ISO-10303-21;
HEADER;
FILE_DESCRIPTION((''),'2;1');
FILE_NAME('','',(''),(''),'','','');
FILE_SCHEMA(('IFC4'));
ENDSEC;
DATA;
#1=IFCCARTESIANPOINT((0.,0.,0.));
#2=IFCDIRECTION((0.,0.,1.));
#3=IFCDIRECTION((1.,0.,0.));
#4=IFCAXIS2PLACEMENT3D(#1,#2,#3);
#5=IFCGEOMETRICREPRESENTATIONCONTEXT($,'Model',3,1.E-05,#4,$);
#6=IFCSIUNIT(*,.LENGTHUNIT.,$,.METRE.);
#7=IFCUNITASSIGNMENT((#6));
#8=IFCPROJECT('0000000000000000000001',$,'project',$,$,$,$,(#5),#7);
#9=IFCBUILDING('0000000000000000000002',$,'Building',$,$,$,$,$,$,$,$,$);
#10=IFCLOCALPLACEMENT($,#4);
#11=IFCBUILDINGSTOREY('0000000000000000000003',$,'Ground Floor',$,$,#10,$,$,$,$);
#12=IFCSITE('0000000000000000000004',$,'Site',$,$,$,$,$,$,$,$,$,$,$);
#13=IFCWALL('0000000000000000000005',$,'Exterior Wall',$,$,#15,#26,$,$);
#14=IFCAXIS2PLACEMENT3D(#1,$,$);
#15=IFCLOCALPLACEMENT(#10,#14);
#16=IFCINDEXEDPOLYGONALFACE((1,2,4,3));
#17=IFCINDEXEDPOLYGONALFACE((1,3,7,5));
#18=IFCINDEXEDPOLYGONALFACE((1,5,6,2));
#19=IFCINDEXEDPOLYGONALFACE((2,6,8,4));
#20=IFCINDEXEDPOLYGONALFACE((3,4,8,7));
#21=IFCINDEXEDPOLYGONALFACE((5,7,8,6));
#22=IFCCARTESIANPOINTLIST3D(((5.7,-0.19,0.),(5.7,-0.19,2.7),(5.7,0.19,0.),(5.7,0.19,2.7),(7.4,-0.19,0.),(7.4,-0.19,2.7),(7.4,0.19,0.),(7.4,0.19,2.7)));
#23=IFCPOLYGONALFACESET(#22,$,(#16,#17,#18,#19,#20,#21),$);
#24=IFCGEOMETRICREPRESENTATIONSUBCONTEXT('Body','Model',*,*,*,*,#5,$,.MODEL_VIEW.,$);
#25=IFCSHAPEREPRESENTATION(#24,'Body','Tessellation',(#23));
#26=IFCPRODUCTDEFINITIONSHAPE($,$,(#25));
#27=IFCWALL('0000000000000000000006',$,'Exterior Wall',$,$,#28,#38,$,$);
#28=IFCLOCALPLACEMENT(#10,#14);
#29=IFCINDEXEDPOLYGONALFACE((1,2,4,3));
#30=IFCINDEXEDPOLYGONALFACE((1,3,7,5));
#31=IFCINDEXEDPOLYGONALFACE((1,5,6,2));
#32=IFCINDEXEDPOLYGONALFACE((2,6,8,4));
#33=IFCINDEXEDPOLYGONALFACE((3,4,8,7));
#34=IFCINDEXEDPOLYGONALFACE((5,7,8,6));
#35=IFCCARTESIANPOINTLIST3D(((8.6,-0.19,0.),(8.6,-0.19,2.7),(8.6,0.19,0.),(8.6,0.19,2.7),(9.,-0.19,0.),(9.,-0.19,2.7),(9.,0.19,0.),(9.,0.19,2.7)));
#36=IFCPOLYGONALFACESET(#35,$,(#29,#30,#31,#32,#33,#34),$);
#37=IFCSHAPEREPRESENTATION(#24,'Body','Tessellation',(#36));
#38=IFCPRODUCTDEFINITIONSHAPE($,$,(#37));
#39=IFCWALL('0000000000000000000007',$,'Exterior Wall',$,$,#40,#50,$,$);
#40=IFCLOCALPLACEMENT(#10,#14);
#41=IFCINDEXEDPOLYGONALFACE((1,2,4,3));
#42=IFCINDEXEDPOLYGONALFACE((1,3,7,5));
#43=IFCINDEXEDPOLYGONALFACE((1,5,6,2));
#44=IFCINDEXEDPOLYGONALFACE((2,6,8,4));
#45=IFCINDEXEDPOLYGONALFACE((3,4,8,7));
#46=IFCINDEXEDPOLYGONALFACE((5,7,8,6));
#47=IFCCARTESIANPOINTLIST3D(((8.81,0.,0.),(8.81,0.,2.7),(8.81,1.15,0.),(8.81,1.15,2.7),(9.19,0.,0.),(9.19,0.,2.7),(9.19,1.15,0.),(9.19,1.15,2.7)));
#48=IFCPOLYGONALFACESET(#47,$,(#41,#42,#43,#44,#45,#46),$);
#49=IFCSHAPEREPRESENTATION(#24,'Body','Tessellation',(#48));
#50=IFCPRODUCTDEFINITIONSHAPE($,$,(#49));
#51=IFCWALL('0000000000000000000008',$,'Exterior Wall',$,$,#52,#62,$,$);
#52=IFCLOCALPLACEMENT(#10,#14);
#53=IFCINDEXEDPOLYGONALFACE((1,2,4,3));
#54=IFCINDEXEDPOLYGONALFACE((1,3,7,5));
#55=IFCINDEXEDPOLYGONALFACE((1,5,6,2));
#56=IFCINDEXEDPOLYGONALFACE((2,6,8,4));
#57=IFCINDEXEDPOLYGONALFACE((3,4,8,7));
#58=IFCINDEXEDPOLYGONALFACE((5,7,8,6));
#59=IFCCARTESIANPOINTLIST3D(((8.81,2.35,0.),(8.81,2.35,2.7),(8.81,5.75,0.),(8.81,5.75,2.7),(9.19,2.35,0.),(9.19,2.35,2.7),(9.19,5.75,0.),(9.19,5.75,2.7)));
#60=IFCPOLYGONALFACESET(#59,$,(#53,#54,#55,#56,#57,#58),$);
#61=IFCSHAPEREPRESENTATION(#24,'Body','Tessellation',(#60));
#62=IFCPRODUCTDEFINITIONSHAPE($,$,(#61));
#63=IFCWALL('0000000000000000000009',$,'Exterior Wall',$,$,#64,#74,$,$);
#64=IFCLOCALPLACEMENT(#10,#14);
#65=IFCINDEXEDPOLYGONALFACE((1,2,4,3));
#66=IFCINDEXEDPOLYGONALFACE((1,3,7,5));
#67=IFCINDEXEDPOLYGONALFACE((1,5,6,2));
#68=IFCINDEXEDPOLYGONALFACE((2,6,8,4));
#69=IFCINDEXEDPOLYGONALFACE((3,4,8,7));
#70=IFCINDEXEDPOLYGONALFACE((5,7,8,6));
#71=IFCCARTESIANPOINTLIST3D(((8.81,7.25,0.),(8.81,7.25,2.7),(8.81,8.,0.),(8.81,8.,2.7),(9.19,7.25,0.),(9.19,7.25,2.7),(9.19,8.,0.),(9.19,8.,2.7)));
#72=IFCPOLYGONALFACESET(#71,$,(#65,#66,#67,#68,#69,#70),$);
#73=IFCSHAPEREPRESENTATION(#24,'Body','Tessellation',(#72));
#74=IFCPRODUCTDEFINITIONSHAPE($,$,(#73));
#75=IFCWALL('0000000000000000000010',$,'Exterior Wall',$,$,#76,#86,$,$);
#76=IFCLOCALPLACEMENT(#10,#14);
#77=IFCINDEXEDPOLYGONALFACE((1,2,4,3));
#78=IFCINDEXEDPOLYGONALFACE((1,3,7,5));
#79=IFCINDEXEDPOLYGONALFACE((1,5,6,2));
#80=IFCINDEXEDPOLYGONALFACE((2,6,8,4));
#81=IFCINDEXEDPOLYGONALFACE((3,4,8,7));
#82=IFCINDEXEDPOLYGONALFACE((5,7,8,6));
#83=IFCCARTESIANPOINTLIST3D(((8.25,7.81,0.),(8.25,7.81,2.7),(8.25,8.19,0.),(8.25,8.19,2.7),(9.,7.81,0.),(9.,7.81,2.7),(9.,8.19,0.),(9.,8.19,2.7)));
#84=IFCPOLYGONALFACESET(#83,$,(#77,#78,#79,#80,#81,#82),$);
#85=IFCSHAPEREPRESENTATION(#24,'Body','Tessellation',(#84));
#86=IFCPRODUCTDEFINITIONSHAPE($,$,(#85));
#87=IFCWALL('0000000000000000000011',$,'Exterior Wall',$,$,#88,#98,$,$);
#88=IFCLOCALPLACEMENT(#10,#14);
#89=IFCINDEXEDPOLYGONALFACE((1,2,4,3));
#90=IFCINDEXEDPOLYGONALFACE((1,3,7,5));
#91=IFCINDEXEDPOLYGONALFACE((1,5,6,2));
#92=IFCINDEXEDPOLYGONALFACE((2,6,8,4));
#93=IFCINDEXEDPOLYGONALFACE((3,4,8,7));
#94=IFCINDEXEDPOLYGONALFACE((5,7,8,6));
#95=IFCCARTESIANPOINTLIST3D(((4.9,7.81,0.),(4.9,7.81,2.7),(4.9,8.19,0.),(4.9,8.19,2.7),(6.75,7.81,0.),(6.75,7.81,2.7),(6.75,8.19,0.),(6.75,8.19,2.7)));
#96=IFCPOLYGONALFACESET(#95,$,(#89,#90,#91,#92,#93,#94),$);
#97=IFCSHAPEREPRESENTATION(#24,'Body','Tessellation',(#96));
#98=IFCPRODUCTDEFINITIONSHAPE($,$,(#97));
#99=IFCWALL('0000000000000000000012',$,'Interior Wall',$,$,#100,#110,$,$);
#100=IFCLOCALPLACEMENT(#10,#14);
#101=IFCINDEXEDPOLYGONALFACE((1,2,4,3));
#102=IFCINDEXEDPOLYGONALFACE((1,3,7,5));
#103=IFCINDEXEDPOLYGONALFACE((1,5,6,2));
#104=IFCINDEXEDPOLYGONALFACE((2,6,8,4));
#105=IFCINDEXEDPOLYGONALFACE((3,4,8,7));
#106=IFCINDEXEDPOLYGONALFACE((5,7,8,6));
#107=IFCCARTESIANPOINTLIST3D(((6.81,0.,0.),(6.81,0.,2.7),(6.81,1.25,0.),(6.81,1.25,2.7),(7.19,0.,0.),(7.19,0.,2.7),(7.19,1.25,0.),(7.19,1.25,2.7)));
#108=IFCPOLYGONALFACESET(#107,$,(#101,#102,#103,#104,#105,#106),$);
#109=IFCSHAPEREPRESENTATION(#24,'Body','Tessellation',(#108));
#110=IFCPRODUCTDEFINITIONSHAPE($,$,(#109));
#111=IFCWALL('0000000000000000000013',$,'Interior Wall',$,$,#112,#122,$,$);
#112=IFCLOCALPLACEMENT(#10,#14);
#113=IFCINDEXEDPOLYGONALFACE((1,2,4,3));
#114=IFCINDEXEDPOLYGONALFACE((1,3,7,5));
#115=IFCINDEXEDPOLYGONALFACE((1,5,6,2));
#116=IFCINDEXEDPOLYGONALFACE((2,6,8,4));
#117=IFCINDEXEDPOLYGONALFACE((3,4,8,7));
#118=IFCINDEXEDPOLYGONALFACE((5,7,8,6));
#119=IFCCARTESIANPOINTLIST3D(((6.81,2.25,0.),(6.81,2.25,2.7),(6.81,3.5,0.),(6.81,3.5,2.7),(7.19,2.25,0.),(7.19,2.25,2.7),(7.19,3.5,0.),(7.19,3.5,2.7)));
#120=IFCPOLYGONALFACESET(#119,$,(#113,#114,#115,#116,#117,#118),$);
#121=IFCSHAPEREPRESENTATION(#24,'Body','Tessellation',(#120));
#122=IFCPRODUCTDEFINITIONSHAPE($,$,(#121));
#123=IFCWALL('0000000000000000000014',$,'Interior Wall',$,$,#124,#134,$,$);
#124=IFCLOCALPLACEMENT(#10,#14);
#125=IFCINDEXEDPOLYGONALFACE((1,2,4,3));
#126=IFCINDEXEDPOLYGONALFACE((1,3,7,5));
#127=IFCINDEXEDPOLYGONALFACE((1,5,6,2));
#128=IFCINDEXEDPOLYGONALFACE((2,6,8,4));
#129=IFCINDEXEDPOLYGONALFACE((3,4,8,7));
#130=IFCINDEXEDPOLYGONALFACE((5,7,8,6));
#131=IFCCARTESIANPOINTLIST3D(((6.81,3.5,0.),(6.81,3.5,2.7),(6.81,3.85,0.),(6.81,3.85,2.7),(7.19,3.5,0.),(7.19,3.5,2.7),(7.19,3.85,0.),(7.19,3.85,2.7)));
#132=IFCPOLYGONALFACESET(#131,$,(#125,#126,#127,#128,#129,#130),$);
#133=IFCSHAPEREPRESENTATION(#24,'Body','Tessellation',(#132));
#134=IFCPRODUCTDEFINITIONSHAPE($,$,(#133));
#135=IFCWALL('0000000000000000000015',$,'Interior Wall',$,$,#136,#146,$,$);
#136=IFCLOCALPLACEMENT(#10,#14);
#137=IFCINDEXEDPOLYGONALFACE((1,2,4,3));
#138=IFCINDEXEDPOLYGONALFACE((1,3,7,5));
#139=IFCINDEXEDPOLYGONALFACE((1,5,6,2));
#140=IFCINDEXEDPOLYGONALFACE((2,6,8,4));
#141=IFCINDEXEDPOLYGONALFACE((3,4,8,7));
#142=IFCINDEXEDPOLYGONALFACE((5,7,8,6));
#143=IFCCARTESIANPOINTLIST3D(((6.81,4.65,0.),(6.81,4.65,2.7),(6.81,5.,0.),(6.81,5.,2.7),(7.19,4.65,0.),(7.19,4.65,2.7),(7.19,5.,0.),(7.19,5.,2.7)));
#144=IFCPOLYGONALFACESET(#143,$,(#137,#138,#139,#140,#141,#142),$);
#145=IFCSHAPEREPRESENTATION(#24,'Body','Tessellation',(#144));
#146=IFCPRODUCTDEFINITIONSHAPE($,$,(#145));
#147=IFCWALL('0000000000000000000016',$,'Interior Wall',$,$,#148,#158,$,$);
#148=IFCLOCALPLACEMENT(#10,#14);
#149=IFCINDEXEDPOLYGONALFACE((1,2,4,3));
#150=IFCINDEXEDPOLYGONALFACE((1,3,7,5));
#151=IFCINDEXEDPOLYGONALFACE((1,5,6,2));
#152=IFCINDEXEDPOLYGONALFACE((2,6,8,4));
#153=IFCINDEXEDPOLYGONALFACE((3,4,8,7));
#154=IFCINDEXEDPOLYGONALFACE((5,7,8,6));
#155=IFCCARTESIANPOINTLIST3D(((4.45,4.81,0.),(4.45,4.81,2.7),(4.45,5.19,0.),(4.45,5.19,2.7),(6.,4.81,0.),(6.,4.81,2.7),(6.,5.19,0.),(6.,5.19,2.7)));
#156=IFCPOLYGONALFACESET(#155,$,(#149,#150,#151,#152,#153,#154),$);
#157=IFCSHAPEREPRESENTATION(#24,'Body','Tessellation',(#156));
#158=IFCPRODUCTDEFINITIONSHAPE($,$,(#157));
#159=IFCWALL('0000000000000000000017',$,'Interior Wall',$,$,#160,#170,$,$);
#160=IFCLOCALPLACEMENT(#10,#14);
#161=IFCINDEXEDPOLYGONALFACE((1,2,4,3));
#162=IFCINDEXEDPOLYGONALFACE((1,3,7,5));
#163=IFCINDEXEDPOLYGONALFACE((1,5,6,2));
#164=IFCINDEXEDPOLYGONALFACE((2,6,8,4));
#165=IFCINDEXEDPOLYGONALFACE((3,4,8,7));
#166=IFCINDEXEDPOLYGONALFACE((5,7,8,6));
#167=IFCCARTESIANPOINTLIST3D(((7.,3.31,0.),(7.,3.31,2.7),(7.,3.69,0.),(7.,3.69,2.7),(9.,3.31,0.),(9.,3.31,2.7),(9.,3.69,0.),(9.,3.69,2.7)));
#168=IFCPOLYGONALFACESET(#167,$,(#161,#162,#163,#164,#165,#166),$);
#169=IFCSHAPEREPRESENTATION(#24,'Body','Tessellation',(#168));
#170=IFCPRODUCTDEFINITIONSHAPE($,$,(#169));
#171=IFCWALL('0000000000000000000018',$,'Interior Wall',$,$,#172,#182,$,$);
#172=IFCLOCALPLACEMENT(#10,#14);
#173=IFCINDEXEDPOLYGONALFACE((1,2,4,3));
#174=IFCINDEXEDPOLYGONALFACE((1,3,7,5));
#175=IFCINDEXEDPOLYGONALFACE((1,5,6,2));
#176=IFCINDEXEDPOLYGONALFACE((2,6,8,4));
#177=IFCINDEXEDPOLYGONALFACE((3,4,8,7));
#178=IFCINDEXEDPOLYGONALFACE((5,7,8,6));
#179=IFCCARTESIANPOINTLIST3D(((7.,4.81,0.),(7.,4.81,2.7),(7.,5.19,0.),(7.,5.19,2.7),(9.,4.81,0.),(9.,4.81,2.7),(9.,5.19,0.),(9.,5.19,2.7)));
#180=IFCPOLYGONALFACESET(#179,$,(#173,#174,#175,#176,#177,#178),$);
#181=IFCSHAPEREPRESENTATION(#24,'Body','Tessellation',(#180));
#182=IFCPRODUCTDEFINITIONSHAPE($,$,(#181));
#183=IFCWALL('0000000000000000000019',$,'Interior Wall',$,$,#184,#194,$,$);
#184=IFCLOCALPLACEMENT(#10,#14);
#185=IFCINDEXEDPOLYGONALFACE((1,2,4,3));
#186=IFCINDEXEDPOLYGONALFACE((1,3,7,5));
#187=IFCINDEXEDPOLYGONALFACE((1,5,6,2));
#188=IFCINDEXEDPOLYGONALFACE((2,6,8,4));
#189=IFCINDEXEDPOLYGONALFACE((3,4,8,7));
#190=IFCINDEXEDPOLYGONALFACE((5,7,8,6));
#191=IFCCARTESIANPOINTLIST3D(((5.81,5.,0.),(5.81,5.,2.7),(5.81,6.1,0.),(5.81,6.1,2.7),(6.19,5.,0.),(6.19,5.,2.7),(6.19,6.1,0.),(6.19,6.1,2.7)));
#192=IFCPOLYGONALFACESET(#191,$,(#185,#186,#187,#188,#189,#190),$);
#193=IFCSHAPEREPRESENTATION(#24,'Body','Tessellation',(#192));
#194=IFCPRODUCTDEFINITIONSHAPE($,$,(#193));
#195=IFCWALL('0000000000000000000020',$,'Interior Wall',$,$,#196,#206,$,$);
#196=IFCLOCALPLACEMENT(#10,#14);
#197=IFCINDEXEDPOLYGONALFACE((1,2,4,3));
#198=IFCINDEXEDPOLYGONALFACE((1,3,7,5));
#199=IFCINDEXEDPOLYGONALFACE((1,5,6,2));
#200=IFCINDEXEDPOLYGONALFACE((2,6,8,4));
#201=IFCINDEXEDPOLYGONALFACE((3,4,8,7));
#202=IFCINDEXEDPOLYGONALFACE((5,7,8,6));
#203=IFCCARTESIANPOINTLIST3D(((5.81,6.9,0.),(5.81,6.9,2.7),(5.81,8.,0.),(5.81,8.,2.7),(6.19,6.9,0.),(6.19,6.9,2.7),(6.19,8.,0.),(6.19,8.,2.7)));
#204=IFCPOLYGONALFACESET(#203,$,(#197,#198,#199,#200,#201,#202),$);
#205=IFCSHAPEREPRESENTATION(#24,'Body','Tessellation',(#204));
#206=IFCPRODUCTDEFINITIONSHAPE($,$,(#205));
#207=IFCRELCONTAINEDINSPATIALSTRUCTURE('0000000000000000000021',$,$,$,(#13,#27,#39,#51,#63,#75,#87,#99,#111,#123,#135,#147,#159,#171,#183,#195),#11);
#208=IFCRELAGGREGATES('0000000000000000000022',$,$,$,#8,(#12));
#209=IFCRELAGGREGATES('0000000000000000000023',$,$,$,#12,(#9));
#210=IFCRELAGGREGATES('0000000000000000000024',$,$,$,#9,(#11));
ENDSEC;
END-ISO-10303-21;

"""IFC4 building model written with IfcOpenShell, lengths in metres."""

from ifc_helpers import new_model, si_unit, frame, origin_with_axes, place, context, subcontext, project, spatial, indexed_curve, outline, extrude, element, save


model = new_model("IFC4")

# Units and contexts
model_context = context("Model", 3, precision=1e-05, world=origin_with_axes())
body_context = subcontext(model_context, "Body", "Model", "MODEL_VIEW")
ifc_project = project(units=[si_unit("LENGTHUNIT", "METRE")], contexts=[model_context])

# Site, building, storey
site = spatial("IfcSite", under=ifc_project, Name="Site")
building = spatial("IfcBuilding", under=site, Name="Building")
storey_placement = place(None, origin_with_axes())
storey = spatial("IfcBuildingStorey", under=building, at=storey_placement, Name="Ground Floor")

# Walls
wall_1_placement = place(storey_placement, frame((5.7, 0.0, 0.0), z_axis=(0.0, 0.0, 1.0), x_axis=(1.0, 0.0, 0.0)))
element("IfcWall", 1, at=wall_1_placement, inside=storey, Name="Exterior Wall", context=body_context, shape_type="SweptSolid", body=[
    extrude(outline(indexed_curve([(0.0, 0.0), (0.0, 0.38), (1.7, 0.38), (1.7, 0.0), (0.0, 0.0)], self_intersect=False)), frame((0.0, -0.19, 0.0), z_axis=(0.0, 0.0, 1.0), x_axis=(1.0, 0.0, 0.0)), (0.0, 0.0, 1.0), 2.7),
])
wall_2_placement = place(storey_placement, frame((8.6, 0.0, 0.0), z_axis=(0.0, 0.0, 1.0), x_axis=(1.0, 0.0, 0.0)))
element("IfcWall", 2, at=wall_2_placement, inside=storey, Name="Exterior Wall", context=body_context, shape_type="SweptSolid", body=[
    extrude(outline(indexed_curve([(0.0, 0.0), (0.0, 0.38), (0.4, 0.38), (0.4, 0.0), (0.0, 0.0)], self_intersect=False)), frame((0.0, -0.19, 0.0), z_axis=(0.0, 0.0, 1.0), x_axis=(1.0, 0.0, 0.0)), (0.0, 0.0, 1.0), 2.7),
])
wall_3_placement = place(storey_placement, frame((9.0, 0.0, 0.0), z_axis=(0.0, 0.0, 1.0), x_axis=(0.0, 1.0, 0.0)))
element("IfcWall", 3, at=wall_3_placement, inside=storey, Name="Exterior Wall", context=body_context, shape_type="SweptSolid", body=[
    extrude(outline(indexed_curve([(0.0, 0.0), (0.0, 0.38), (1.15, 0.38), (1.15, 0.0), (0.0, 0.0)], self_intersect=False)), frame((0.0, -0.19, 0.0), z_axis=(0.0, 0.0, 1.0), x_axis=(1.0, 0.0, 0.0)), (0.0, 0.0, 1.0), 2.7),
])
wall_4_placement = place(storey_placement, frame((9.0, 2.35, 0.0), z_axis=(0.0, 0.0, 1.0), x_axis=(0.0, 1.0, 0.0)))
element("IfcWall", 4, at=wall_4_placement, inside=storey, Name="Exterior Wall", context=body_context, shape_type="SweptSolid", body=[
    extrude(outline(indexed_curve([(0.0, 0.0), (0.0, 0.38), (3.4, 0.38), (3.4, 0.0), (0.0, 0.0)], self_intersect=False)), frame((0.0, -0.19, 0.0), z_axis=(0.0, 0.0, 1.0), x_axis=(1.0, 0.0, 0.0)), (0.0, 0.0, 1.0), 2.7),
])
for number, where, z_axis, x_axis, name in (
    (5, (9.0, 7.25, 0.0), (0.0, 0.0, 1.0), (0.0, 1.0, 0.0), "Exterior Wall"),
    (6, (9.0, 8.0, 0.0), (0.0, 0.0, 1.0), (-1.0, 0.0, 0.0), "Exterior Wall"),
):
    element("IfcWall", number, at=place(storey_placement, frame(where, z_axis=z_axis, x_axis=x_axis)), inside=storey, Name=name, context=body_context, shape_type="SweptSolid", body=[
        extrude(outline(indexed_curve([(0.0, 0.0), (0.0, 0.38), (0.75, 0.38), (0.75, 0.0), (0.0, 0.0)], self_intersect=False)), frame((0.0, -0.19, 0.0), z_axis=(0.0, 0.0, 1.0), x_axis=(1.0, 0.0, 0.0)), (0.0, 0.0, 1.0), 2.7),
    ])
wall_5_placement = place(storey_placement, frame((6.75, 8.0, 0.0), z_axis=(0.0, 0.0, 1.0), x_axis=(-1.0, 0.0, 0.0)))
element("IfcWall", 7, at=wall_5_placement, inside=storey, Name="Exterior Wall", context=body_context, shape_type="SweptSolid", body=[
    extrude(outline(indexed_curve([(0.0, 0.0), (0.0, 0.38), (1.85, 0.38), (1.85, 0.0), (0.0, 0.0)], self_intersect=False)), frame((0.0, -0.19, 0.0), z_axis=(0.0, 0.0, 1.0), x_axis=(1.0, 0.0, 0.0)), (0.0, 0.0, 1.0), 2.7),
])
for number, where, z_axis, x_axis, name in (
    (8, (7.0, 0.0, 0.0), (0.0, 0.0, 1.0), (0.0, 1.0, 0.0), "Interior Wall"),
    (9, (7.0, 2.25, 0.0), (0.0, 0.0, 1.0), (0.0, 1.0, 0.0), "Interior Wall"),
):
    element("IfcWall", number, at=place(storey_placement, frame(where, z_axis=z_axis, x_axis=x_axis)), inside=storey, Name=name, context=body_context, shape_type="SweptSolid", body=[
        extrude(outline(indexed_curve([(0.0, 0.0), (0.0, 0.38), (1.25, 0.38), (1.25, 0.0), (0.0, 0.0)], self_intersect=False)), frame((0.0, -0.19, 0.0), z_axis=(0.0, 0.0, 1.0), x_axis=(1.0, 0.0, 0.0)), (0.0, 0.0, 1.0), 2.7),
    ])
wall_6_placement = place(storey_placement, frame((7.0, 3.5, 0.0), z_axis=(0.0, 0.0, 1.0), x_axis=(0.0, 1.0, 0.0)))
element("IfcWall", 10, at=wall_6_placement, inside=storey, Name="Interior Wall", context=body_context, shape_type="SweptSolid", body=[
    extrude(outline(indexed_curve([(0.0, 0.0), (0.0, 0.38), (0.35, 0.38), (0.35, 0.0), (0.0, 0.0)], self_intersect=False)), frame((0.0, -0.19, 0.0), z_axis=(0.0, 0.0, 1.0), x_axis=(1.0, 0.0, 0.0)), (0.0, 0.0, 1.0), 2.7),
])
wall_7_placement = place(storey_placement, frame((7.0, 4.65, 0.0), z_axis=(0.0, 0.0, 1.0), x_axis=(0.0, 1.0, 0.0)))
element("IfcWall", 11, at=wall_7_placement, inside=storey, Name="Interior Wall", context=body_context, shape_type="SweptSolid", body=[
    extrude(outline(indexed_curve([(0.0, 0.0), (0.0, 0.38), (0.35, 0.38), (0.35, 0.0), (0.0, 0.0)], self_intersect=False)), frame((0.0, -0.19, 0.0), z_axis=(0.0, 0.0, 1.0), x_axis=(1.0, 0.0, 0.0)), (0.0, 0.0, 1.0), 2.7),
])
wall_8_placement = place(storey_placement, frame((6.0, 5.0, 0.0), z_axis=(0.0, 0.0, 1.0), x_axis=(-1.0, 0.0, 0.0)))
element("IfcWall", 12, at=wall_8_placement, inside=storey, Name="Interior Wall", context=body_context, shape_type="SweptSolid", body=[
    extrude(outline(indexed_curve([(0.0, 0.0), (0.0, 0.38), (1.55, 0.38), (1.55, 0.0), (0.0, 0.0)], self_intersect=False)), frame((0.0, -0.19, 0.0), z_axis=(0.0, 0.0, 1.0), x_axis=(1.0, 0.0, 0.0)), (0.0, 0.0, 1.0), 2.7),
])
for number, where, z_axis, x_axis, name in (
    (13, (9.0, 3.5, 0.0), (0.0, 0.0, 1.0), (-1.0, 0.0, 0.0), "Interior Wall"),
    (14, (9.0, 5.0, 0.0), (0.0, 0.0, 1.0), (-1.0, 0.0, 0.0), "Interior Wall"),
):
    element("IfcWall", number, at=place(storey_placement, frame(where, z_axis=z_axis, x_axis=x_axis)), inside=storey, Name=name, context=body_context, shape_type="SweptSolid", body=[
        extrude(outline(indexed_curve([(0.0, 0.0), (0.0, 0.38), (2.0, 0.38), (2.0, 0.0), (0.0, 0.0)], self_intersect=False)), frame((0.0, -0.19, 0.0), z_axis=(0.0, 0.0, 1.0), x_axis=(1.0, 0.0, 0.0)), (0.0, 0.0, 1.0), 2.7),
    ])
for number, where, z_axis, x_axis, name in (
    (15, (6.0, 5.0, 0.0), (0.0, 0.0, 1.0), (0.0, 1.0, 0.0), "Interior Wall"),
    (16, (6.0, 6.9, 0.0), (0.0, 0.0, 1.0), (0.0, 1.0, 0.0), "Interior Wall"),
):
    element("IfcWall", number, at=place(storey_placement, frame(where, z_axis=z_axis, x_axis=x_axis)), inside=storey, Name=name, context=body_context, shape_type="SweptSolid", body=[
        extrude(outline(indexed_curve([(0.0, 0.0), (0.0, 0.38), (1.1, 0.38), (1.1, 0.0), (0.0, 0.0)], self_intersect=False)), frame((0.0, -0.19, 0.0), z_axis=(0.0, 0.0, 1.0), x_axis=(1.0, 0.0, 0.0)), (0.0, 0.0, 1.0), 2.7),
    ])

save(model, "model.ifc")
